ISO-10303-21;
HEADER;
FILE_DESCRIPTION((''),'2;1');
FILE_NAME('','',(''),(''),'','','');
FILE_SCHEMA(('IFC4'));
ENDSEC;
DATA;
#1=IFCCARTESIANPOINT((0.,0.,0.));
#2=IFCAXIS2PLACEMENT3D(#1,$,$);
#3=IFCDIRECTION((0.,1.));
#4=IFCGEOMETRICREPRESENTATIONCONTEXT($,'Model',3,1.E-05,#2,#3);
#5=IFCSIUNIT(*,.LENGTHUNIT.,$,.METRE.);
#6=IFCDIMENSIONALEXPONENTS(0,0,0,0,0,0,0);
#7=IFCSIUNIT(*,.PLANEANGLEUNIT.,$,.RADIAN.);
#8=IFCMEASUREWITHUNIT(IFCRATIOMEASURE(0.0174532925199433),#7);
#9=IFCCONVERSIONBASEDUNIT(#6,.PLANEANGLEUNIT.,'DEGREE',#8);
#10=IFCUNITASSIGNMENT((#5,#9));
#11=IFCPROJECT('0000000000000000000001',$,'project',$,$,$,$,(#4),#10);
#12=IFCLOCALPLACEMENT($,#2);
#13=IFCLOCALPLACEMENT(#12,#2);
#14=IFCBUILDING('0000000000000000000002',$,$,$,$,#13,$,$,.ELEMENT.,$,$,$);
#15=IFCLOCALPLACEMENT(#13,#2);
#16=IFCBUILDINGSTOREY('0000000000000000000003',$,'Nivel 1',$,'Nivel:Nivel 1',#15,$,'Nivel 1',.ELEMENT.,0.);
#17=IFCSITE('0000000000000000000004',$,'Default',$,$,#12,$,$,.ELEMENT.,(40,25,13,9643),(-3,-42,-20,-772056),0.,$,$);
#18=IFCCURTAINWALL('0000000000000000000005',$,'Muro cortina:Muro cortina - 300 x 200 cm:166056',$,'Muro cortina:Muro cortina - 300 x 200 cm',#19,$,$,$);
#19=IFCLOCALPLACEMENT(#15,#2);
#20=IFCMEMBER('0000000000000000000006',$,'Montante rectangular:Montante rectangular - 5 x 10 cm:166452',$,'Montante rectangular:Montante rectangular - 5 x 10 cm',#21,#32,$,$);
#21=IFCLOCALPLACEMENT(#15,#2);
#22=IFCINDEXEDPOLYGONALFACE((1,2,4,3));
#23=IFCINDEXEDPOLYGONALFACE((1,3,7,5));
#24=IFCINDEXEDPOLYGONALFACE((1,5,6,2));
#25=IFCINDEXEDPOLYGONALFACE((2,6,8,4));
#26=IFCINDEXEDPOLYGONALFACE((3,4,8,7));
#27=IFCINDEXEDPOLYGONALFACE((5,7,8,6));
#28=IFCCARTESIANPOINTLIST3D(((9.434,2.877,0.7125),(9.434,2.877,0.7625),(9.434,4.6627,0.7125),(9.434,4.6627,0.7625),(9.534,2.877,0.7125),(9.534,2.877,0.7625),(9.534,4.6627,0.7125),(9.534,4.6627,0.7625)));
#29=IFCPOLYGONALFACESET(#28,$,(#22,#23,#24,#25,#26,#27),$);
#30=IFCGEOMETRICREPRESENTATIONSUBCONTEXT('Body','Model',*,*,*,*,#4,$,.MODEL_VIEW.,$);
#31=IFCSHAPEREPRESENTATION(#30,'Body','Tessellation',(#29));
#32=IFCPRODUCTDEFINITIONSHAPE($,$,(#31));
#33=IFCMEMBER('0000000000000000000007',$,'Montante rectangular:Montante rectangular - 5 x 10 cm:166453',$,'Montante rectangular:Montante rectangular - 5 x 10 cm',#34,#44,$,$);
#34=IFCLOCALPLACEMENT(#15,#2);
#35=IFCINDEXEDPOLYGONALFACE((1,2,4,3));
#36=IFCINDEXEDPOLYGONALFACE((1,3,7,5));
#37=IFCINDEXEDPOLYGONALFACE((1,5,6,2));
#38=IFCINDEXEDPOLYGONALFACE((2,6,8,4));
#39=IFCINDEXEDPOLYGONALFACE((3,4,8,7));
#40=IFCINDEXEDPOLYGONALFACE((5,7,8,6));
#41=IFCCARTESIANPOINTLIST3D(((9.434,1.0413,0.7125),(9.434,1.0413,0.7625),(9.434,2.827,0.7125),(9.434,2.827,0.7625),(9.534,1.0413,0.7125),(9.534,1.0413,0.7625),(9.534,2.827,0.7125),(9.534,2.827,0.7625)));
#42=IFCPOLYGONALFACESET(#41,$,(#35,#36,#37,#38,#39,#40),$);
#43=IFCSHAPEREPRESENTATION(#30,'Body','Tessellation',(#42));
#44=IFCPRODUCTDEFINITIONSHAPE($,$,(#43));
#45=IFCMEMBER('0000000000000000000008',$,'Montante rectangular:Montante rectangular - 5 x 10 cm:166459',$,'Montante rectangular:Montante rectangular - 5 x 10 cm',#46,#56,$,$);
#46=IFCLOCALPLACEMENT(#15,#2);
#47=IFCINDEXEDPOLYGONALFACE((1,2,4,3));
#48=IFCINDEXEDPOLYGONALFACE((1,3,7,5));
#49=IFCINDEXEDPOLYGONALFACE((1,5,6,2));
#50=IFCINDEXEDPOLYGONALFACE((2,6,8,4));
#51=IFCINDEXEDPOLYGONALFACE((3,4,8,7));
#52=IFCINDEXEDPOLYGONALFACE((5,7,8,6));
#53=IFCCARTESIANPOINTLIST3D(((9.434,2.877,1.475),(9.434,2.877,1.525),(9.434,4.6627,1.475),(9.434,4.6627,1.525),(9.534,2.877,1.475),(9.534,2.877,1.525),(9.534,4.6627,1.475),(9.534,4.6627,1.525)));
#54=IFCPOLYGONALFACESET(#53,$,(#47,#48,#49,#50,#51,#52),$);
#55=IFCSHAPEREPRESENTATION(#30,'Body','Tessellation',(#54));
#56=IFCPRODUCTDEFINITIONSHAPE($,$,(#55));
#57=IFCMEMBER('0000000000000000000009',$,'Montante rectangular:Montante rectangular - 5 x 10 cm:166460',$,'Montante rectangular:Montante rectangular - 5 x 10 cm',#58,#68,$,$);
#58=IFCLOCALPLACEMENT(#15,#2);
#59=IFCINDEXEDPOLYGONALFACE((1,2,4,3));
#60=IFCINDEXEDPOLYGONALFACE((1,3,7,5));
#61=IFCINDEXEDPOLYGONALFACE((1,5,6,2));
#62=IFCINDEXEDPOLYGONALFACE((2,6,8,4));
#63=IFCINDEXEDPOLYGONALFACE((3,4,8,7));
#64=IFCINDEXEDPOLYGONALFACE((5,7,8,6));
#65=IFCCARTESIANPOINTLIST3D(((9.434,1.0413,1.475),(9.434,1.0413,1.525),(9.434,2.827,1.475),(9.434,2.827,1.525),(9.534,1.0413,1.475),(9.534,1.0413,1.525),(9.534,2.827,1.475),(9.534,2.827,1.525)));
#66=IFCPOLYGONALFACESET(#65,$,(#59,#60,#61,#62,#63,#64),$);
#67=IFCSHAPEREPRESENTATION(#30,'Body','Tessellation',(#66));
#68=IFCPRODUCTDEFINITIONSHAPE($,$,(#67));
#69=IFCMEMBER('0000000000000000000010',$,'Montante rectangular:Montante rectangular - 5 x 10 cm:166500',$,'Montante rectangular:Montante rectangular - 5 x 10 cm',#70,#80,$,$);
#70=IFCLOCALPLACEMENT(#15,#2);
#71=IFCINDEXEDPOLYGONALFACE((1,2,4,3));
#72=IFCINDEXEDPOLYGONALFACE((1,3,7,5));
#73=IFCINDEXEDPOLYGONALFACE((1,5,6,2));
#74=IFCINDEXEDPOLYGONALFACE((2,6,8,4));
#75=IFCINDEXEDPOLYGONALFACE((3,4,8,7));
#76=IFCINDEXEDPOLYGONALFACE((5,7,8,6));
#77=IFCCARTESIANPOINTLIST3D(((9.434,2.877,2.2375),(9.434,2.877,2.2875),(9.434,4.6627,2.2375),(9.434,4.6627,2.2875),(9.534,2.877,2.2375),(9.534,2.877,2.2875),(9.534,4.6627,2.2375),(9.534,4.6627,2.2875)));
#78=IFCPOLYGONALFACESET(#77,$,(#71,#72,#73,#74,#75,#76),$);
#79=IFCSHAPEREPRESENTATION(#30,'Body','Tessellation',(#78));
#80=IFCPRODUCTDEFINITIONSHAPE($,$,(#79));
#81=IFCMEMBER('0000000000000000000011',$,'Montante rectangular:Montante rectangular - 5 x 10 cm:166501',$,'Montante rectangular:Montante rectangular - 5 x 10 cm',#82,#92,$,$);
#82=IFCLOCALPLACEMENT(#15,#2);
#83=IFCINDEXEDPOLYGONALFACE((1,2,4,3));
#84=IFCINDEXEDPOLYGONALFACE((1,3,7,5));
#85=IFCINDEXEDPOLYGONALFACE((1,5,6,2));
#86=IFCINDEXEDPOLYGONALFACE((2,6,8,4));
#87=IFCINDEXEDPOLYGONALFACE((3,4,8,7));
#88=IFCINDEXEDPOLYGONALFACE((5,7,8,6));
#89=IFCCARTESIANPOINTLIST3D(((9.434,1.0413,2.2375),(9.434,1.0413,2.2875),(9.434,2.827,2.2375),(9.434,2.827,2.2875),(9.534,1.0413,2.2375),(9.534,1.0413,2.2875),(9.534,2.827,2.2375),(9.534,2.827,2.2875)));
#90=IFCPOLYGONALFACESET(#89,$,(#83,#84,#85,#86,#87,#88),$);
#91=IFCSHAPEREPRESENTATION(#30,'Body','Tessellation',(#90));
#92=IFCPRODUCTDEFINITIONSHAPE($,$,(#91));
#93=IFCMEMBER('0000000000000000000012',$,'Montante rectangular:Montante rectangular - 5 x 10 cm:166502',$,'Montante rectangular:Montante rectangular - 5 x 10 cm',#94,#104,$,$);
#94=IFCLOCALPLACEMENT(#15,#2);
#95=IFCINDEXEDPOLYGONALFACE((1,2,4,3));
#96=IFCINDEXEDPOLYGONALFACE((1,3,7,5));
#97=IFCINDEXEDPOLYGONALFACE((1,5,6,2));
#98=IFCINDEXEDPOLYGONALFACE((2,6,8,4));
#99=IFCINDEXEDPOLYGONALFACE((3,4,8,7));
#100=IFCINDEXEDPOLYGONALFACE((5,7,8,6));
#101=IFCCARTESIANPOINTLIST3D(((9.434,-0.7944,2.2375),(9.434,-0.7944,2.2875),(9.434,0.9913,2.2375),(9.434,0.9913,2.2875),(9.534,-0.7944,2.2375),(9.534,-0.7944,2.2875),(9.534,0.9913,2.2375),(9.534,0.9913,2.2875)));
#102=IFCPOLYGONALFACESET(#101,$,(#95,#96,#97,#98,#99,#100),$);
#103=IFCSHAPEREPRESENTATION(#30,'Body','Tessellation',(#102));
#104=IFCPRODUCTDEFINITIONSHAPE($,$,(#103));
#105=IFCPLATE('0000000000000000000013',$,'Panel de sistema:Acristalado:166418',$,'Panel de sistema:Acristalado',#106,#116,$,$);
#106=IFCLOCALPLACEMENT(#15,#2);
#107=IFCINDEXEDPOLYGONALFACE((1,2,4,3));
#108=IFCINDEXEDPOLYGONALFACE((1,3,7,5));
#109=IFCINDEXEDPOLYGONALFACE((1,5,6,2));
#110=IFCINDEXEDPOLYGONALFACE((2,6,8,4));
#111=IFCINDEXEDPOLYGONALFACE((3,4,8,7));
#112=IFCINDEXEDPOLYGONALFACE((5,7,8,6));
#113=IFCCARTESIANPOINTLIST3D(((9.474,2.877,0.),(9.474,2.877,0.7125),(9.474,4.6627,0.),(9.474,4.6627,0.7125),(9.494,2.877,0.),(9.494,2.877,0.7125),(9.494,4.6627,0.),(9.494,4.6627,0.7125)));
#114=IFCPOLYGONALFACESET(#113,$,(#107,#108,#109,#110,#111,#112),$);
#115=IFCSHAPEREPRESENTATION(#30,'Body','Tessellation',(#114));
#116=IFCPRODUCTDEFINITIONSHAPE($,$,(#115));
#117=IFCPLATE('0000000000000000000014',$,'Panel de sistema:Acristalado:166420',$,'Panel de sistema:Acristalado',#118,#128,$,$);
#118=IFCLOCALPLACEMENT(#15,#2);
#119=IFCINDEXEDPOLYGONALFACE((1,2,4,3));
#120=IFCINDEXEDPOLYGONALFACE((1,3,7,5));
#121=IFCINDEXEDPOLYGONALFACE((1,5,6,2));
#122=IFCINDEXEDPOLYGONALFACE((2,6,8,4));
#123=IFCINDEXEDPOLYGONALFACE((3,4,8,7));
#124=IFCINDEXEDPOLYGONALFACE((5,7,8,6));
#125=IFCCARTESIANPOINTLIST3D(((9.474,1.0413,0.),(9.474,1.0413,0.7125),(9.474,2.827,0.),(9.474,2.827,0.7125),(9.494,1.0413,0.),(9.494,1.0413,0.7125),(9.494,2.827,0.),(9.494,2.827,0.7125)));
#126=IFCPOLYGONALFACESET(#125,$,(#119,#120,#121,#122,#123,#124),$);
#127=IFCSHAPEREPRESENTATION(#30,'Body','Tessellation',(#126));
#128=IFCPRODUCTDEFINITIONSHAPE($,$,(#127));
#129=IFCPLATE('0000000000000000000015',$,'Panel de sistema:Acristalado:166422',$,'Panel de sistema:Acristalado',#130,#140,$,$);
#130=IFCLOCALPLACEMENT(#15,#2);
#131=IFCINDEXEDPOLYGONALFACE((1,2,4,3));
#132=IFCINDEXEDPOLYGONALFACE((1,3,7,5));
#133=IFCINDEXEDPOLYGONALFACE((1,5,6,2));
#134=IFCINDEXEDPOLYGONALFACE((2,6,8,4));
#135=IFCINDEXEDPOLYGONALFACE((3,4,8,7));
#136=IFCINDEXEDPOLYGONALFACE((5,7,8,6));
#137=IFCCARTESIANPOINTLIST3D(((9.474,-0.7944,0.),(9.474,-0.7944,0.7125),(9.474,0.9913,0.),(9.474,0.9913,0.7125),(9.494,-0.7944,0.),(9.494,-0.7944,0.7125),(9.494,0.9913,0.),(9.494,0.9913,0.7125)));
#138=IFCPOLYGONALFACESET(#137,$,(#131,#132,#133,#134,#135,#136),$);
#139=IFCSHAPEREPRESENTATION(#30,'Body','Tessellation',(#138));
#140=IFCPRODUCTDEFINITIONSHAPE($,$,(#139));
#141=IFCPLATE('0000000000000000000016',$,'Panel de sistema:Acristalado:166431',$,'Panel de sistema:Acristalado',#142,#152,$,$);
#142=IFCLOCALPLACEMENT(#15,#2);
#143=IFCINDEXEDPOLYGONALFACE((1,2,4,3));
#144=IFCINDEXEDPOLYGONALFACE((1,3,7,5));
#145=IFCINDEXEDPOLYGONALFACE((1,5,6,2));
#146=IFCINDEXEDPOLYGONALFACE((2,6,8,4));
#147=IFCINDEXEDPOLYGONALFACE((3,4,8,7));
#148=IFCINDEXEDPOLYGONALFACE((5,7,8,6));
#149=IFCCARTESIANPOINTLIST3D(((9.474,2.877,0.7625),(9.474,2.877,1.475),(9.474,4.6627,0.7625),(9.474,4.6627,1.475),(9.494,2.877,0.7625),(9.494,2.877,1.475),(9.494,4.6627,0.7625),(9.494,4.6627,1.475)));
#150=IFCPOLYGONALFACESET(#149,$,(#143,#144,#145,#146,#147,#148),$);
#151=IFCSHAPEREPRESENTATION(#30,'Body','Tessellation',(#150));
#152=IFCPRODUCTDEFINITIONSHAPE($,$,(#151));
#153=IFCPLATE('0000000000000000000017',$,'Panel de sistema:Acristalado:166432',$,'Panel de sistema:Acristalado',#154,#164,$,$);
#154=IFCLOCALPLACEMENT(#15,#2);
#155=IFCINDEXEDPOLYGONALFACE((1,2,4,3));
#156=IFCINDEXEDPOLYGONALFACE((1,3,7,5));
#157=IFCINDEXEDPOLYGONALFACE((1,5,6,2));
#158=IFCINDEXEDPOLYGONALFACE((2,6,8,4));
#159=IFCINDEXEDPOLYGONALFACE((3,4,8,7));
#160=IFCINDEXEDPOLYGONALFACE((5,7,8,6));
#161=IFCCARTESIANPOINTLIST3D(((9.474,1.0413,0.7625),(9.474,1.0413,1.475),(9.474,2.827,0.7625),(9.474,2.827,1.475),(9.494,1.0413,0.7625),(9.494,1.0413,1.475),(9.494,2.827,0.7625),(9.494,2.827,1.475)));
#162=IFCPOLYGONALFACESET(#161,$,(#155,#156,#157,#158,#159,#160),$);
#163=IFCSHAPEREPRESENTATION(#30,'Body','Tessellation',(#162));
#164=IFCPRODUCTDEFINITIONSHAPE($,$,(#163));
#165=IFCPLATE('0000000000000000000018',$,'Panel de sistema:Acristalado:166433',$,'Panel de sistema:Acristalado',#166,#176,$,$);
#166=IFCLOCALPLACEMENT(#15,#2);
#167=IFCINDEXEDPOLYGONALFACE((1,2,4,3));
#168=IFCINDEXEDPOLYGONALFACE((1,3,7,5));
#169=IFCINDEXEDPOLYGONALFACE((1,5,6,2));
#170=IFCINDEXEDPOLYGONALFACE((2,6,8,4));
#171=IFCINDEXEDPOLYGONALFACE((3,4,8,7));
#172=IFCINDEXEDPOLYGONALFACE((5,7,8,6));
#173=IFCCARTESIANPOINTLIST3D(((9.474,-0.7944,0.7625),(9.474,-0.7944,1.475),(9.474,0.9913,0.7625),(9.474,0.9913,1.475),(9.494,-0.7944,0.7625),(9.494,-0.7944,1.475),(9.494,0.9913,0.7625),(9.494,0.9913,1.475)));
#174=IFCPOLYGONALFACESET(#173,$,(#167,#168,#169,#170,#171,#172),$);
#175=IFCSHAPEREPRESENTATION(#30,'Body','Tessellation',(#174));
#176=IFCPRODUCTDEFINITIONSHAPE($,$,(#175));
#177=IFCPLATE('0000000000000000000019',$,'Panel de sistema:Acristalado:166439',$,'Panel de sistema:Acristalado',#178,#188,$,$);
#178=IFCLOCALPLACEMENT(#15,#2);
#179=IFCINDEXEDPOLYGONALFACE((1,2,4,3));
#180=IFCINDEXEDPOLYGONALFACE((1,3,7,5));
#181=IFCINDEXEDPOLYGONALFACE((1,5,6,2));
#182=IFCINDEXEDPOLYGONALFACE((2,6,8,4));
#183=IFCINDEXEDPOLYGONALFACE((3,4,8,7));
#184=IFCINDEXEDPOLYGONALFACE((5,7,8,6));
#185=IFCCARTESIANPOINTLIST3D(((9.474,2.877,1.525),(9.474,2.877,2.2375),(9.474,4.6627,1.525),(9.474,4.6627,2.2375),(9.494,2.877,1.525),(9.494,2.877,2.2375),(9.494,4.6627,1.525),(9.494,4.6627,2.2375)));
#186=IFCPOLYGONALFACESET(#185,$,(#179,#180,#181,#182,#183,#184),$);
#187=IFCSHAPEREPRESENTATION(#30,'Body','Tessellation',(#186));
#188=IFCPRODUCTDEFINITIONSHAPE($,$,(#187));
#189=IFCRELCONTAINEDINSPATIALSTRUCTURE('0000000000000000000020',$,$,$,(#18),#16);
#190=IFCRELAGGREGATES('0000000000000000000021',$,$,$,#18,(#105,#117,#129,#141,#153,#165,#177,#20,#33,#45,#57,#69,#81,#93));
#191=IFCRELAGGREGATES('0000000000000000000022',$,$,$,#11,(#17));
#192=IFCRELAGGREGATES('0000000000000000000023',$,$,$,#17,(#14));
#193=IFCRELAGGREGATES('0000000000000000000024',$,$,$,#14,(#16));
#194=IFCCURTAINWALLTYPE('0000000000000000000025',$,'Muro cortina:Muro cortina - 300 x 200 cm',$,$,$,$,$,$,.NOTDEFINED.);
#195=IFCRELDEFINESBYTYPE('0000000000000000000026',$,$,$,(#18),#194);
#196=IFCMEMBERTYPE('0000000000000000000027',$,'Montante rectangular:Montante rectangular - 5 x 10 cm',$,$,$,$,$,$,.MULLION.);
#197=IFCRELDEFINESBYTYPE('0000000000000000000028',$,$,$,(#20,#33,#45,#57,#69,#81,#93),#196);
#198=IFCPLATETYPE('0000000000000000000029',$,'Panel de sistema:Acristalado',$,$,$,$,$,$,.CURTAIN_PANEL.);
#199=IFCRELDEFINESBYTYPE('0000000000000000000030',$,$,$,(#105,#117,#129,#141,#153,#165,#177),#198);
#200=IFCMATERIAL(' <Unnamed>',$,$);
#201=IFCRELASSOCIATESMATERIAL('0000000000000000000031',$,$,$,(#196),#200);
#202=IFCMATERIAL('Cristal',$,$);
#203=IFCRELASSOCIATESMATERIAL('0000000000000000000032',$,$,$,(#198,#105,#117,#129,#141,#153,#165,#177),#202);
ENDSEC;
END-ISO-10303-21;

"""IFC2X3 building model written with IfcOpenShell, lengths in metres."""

from ifc_helpers import new_model, entity, si_unit, converted_unit, direction, frame, origin, origin_2d_with_axis, place, context, subcontext, project, spatial, rectangle, extrude, source, transform, mapped, material, type_object, type_shapes, element, aggregate, save


model = new_model("IFC2X3")

# Units and contexts
model_context = context("Model", 3, precision=1e-05, world=origin(), true_north=direction((0.0, 1.0)))
body_context = subcontext(model_context, "Body", "Model", "MODEL_VIEW")
ifc_project = project(units=[si_unit("LENGTHUNIT", "METRE"), converted_unit("PLANEANGLEUNIT", "DEGREE", entity("IfcRatioMeasure", 0.0174532925199433), si_unit("PLANEANGLEUNIT", "RADIAN"), dimensions=[0, 0, 0, 0, 0, 0, 0])], contexts=[model_context])

# Site, building, storey
site_placement = place(None, origin())
site = spatial("IfcSite", under=ifc_project, at=site_placement, Name="Default", CompositionType="ELEMENT", RefLatitude=(40, 25, 13, 9643), RefLongitude=(-3, -42, -20, -772056), RefElevation=0.0)
building_placement = place(site_placement, origin())
building = spatial("IfcBuilding", under=site, at=building_placement, CompositionType="ELEMENT")
storey_placement = place(building_placement, origin())
storey = spatial("IfcBuildingStorey", under=building, at=storey_placement, Name="Nivel 1", ObjectType="Nivel:Nivel 1", LongName="Nivel 1", CompositionType="ELEMENT", Elevation=0.0)

# Curtain wall, members, plates
curtain_wall_type = type_object("IfcCurtainWallType", Name="Muro cortina:Muro cortina - 300 x 200 cm", PredefinedType="NOTDEFINED")
curtain_wall_placement = place(storey_placement, origin())
curtain_wall = element("IfcCurtainWall", 1, at=curtain_wall_placement, inside=storey, type_object=curtain_wall_type, Name="Muro cortina:Muro cortina - 300 x 200 cm:166056", ObjectType="Muro cortina:Muro cortina - 300 x 200 cm")
ifc_material_1 = material(Name=" <Unnamed>")
member_type_1 = type_object("IfcMemberType", Name="Montante rectangular:Montante rectangular - 5 x 10 cm", PredefinedType="MULLION", material=ifc_material_1)
shared_shape_1 = source(origin(), body_context, "Body", "SweptSolid", [
    extrude(rectangle(XDim=0.1, YDim=0.05, at=origin_2d_with_axis()), frame((0.0, 0.0, -1.7857), z_axis=(0.0, 0.0, 1.0), x_axis=(0.0, -1.0, 0.0)), (0.0, 0.0, 1.0), 1.7857),
])
type_shapes(member_type_1, [shared_shape_1])
member_1_placement = place(storey_placement, frame((9.484, 2.877, 0.7375), z_axis=(0.0, -1.0, 0.0), x_axis=(0.0, 0.0, 1.0)))
member_1 = element("IfcMember", 2, at=member_1_placement, type_object=member_type_1, Name="Montante rectangular:Montante rectangular - 5 x 10 cm:166452", ObjectType="Montante rectangular:Montante rectangular - 5 x 10 cm", context=body_context, shape_type="MappedRepresentation", body=[
    mapped(shared_shape_1, transform((0.0, 0.0, 0.0), scale=1.0)),
])
member_2_placement = place(storey_placement, frame((9.484, 1.0413, 0.7375), z_axis=(0.0, -1.0, 0.0), x_axis=(0.0, 0.0, 1.0)))
member_2 = element("IfcMember", 3, at=member_2_placement, type_object=member_type_1, Name="Montante rectangular:Montante rectangular - 5 x 10 cm:166453", ObjectType="Montante rectangular:Montante rectangular - 5 x 10 cm", context=body_context, shape_type="MappedRepresentation", body=[
    mapped(shared_shape_1, transform((0.0, 0.0, 0.0), scale=1.0)),
])
member_3_placement = place(storey_placement, frame((9.484, 2.877, 1.5), z_axis=(0.0, -1.0, 0.0), x_axis=(0.0, 0.0, 1.0)))
member_3 = element("IfcMember", 4, at=member_3_placement, type_object=member_type_1, Name="Montante rectangular:Montante rectangular - 5 x 10 cm:166459", ObjectType="Montante rectangular:Montante rectangular - 5 x 10 cm", context=body_context, shape_type="MappedRepresentation", body=[
    mapped(shared_shape_1, transform((0.0, 0.0, 0.0), scale=1.0)),
])
member_4_placement = place(storey_placement, frame((9.484, 1.0413, 1.5), z_axis=(0.0, -1.0, 0.0), x_axis=(0.0, 0.0, 1.0)))
member_4 = element("IfcMember", 5, at=member_4_placement, type_object=member_type_1, Name="Montante rectangular:Montante rectangular - 5 x 10 cm:166460", ObjectType="Montante rectangular:Montante rectangular - 5 x 10 cm", context=body_context, shape_type="MappedRepresentation", body=[
    mapped(shared_shape_1, transform((0.0, 0.0, 0.0), scale=1.0)),
])
member_5_placement = place(storey_placement, frame((9.484, 2.877, 2.2625), z_axis=(0.0, -1.0, 0.0), x_axis=(0.0, 0.0, 1.0)))
member_5 = element("IfcMember", 6, at=member_5_placement, type_object=member_type_1, Name="Montante rectangular:Montante rectangular - 5 x 10 cm:166500", ObjectType="Montante rectangular:Montante rectangular - 5 x 10 cm", context=body_context, shape_type="MappedRepresentation", body=[
    mapped(shared_shape_1, transform((0.0, 0.0, 0.0), scale=1.0)),
])
member_6_placement = place(storey_placement, frame((9.484, 1.0413, 2.2625), z_axis=(0.0, -1.0, 0.0), x_axis=(0.0, 0.0, 1.0)))
member_6 = element("IfcMember", 7, at=member_6_placement, type_object=member_type_1, Name="Montante rectangular:Montante rectangular - 5 x 10 cm:166501", ObjectType="Montante rectangular:Montante rectangular - 5 x 10 cm", context=body_context, shape_type="MappedRepresentation", body=[
    mapped(shared_shape_1, transform((0.0, 0.0, 0.0), scale=1.0)),
])
member_7_placement = place(storey_placement, frame((9.484, -0.7944, 2.2625), z_axis=(0.0, -1.0, 0.0), x_axis=(0.0, 0.0, 1.0)))
member_7 = element("IfcMember", 8, at=member_7_placement, type_object=member_type_1, Name="Montante rectangular:Montante rectangular - 5 x 10 cm:166502", ObjectType="Montante rectangular:Montante rectangular - 5 x 10 cm", context=body_context, shape_type="MappedRepresentation", body=[
    mapped(shared_shape_1, transform((0.0, 0.0, 0.0), scale=1.0)),
])
ifc_material_2 = material(Name="Cristal")
plate_type = type_object("IfcPlateType", Name="Panel de sistema:Acristalado", PredefinedType="CURTAIN_PANEL", material=ifc_material_2)
shared_shape_2 = source(origin(), body_context, "Body", "SweptSolid", [
    extrude(rectangle(XDim=0.02, YDim=1.7857, at=origin_2d_with_axis()), frame((0.0, 0.0, 0.0), z_axis=(0.0, 0.0, 1.0), x_axis=(0.0, 1.0, 0.0)), (0.0, 0.0, 1.0), 0.7125),
])
type_shapes(plate_type, [shared_shape_2])
plate_1_placement = place(curtain_wall_placement, frame((9.484, 3.7699, 0.0), z_axis=(0.0, 0.0, 1.0), x_axis=(0.0, -1.0, 0.0)))
plate_1 = element("IfcPlate", 9, at=plate_1_placement, type_object=plate_type, material=ifc_material_2, Name="Panel de sistema:Acristalado:166418", ObjectType="Panel de sistema:Acristalado", context=body_context, shape_type="MappedRepresentation", body=[
    mapped(shared_shape_2, transform((0.0, 0.0, 0.0), scale=1.0)),
])
plate_2_placement = place(curtain_wall_placement, frame((9.484, 1.9342, 0.0), z_axis=(0.0, 0.0, 1.0), x_axis=(0.0, -1.0, 0.0)))
plate_2 = element("IfcPlate", 10, at=plate_2_placement, type_object=plate_type, material=ifc_material_2, Name="Panel de sistema:Acristalado:166420", ObjectType="Panel de sistema:Acristalado", context=body_context, shape_type="MappedRepresentation", body=[
    mapped(shared_shape_2, transform((0.0, 0.0, 0.0), scale=1.0)),
])
plate_3_placement = place(curtain_wall_placement, frame((9.484, 0.0985, 0.0), z_axis=(0.0, 0.0, 1.0), x_axis=(0.0, -1.0, 0.0)))
plate_3 = element("IfcPlate", 11, at=plate_3_placement, type_object=plate_type, material=ifc_material_2, Name="Panel de sistema:Acristalado:166422", ObjectType="Panel de sistema:Acristalado", context=body_context, shape_type="MappedRepresentation", body=[
    mapped(shared_shape_2, transform((0.0, 0.0, 0.0), scale=1.0)),
])
plate_4_placement = place(curtain_wall_placement, frame((9.484, 3.7699, 0.7625), z_axis=(0.0, 0.0, 1.0), x_axis=(0.0, -1.0, 0.0)))
plate_4 = element("IfcPlate", 12, at=plate_4_placement, type_object=plate_type, material=ifc_material_2, Name="Panel de sistema:Acristalado:166431", ObjectType="Panel de sistema:Acristalado", context=body_context, shape_type="MappedRepresentation", body=[
    mapped(shared_shape_2, transform((0.0, 0.0, 0.0), scale=1.0)),
])
plate_5_placement = place(curtain_wall_placement, frame((9.484, 1.9342, 0.7625), z_axis=(0.0, 0.0, 1.0), x_axis=(0.0, -1.0, 0.0)))
plate_5 = element("IfcPlate", 13, at=plate_5_placement, type_object=plate_type, material=ifc_material_2, Name="Panel de sistema:Acristalado:166432", ObjectType="Panel de sistema:Acristalado", context=body_context, shape_type="MappedRepresentation", body=[
    mapped(shared_shape_2, transform((0.0, 0.0, 0.0), scale=1.0)),
])
plate_6_placement = place(curtain_wall_placement, frame((9.484, 0.0985, 0.7625), z_axis=(0.0, 0.0, 1.0), x_axis=(0.0, -1.0, 0.0)))
plate_6 = element("IfcPlate", 14, at=plate_6_placement, type_object=plate_type, material=ifc_material_2, Name="Panel de sistema:Acristalado:166433", ObjectType="Panel de sistema:Acristalado", context=body_context, shape_type="MappedRepresentation", body=[
    mapped(shared_shape_2, transform((0.0, 0.0, 0.0), scale=1.0)),
])
plate_7_placement = place(curtain_wall_placement, frame((9.484, 3.7699, 1.525), z_axis=(0.0, 0.0, 1.0), x_axis=(0.0, -1.0, 0.0)))
plate_7 = element("IfcPlate", 15, at=plate_7_placement, type_object=plate_type, material=ifc_material_2, Name="Panel de sistema:Acristalado:166439", ObjectType="Panel de sistema:Acristalado", context=body_context, shape_type="MappedRepresentation", body=[
    mapped(shared_shape_2, transform((0.0, 0.0, 0.0), scale=1.0)),
])
aggregate(curtain_wall, [plate_1, plate_2, plate_3, plate_4, plate_5, plate_6, plate_7, member_1, member_2, member_3, member_4, member_5, member_6, member_7])

save(model, "model.ifc")
